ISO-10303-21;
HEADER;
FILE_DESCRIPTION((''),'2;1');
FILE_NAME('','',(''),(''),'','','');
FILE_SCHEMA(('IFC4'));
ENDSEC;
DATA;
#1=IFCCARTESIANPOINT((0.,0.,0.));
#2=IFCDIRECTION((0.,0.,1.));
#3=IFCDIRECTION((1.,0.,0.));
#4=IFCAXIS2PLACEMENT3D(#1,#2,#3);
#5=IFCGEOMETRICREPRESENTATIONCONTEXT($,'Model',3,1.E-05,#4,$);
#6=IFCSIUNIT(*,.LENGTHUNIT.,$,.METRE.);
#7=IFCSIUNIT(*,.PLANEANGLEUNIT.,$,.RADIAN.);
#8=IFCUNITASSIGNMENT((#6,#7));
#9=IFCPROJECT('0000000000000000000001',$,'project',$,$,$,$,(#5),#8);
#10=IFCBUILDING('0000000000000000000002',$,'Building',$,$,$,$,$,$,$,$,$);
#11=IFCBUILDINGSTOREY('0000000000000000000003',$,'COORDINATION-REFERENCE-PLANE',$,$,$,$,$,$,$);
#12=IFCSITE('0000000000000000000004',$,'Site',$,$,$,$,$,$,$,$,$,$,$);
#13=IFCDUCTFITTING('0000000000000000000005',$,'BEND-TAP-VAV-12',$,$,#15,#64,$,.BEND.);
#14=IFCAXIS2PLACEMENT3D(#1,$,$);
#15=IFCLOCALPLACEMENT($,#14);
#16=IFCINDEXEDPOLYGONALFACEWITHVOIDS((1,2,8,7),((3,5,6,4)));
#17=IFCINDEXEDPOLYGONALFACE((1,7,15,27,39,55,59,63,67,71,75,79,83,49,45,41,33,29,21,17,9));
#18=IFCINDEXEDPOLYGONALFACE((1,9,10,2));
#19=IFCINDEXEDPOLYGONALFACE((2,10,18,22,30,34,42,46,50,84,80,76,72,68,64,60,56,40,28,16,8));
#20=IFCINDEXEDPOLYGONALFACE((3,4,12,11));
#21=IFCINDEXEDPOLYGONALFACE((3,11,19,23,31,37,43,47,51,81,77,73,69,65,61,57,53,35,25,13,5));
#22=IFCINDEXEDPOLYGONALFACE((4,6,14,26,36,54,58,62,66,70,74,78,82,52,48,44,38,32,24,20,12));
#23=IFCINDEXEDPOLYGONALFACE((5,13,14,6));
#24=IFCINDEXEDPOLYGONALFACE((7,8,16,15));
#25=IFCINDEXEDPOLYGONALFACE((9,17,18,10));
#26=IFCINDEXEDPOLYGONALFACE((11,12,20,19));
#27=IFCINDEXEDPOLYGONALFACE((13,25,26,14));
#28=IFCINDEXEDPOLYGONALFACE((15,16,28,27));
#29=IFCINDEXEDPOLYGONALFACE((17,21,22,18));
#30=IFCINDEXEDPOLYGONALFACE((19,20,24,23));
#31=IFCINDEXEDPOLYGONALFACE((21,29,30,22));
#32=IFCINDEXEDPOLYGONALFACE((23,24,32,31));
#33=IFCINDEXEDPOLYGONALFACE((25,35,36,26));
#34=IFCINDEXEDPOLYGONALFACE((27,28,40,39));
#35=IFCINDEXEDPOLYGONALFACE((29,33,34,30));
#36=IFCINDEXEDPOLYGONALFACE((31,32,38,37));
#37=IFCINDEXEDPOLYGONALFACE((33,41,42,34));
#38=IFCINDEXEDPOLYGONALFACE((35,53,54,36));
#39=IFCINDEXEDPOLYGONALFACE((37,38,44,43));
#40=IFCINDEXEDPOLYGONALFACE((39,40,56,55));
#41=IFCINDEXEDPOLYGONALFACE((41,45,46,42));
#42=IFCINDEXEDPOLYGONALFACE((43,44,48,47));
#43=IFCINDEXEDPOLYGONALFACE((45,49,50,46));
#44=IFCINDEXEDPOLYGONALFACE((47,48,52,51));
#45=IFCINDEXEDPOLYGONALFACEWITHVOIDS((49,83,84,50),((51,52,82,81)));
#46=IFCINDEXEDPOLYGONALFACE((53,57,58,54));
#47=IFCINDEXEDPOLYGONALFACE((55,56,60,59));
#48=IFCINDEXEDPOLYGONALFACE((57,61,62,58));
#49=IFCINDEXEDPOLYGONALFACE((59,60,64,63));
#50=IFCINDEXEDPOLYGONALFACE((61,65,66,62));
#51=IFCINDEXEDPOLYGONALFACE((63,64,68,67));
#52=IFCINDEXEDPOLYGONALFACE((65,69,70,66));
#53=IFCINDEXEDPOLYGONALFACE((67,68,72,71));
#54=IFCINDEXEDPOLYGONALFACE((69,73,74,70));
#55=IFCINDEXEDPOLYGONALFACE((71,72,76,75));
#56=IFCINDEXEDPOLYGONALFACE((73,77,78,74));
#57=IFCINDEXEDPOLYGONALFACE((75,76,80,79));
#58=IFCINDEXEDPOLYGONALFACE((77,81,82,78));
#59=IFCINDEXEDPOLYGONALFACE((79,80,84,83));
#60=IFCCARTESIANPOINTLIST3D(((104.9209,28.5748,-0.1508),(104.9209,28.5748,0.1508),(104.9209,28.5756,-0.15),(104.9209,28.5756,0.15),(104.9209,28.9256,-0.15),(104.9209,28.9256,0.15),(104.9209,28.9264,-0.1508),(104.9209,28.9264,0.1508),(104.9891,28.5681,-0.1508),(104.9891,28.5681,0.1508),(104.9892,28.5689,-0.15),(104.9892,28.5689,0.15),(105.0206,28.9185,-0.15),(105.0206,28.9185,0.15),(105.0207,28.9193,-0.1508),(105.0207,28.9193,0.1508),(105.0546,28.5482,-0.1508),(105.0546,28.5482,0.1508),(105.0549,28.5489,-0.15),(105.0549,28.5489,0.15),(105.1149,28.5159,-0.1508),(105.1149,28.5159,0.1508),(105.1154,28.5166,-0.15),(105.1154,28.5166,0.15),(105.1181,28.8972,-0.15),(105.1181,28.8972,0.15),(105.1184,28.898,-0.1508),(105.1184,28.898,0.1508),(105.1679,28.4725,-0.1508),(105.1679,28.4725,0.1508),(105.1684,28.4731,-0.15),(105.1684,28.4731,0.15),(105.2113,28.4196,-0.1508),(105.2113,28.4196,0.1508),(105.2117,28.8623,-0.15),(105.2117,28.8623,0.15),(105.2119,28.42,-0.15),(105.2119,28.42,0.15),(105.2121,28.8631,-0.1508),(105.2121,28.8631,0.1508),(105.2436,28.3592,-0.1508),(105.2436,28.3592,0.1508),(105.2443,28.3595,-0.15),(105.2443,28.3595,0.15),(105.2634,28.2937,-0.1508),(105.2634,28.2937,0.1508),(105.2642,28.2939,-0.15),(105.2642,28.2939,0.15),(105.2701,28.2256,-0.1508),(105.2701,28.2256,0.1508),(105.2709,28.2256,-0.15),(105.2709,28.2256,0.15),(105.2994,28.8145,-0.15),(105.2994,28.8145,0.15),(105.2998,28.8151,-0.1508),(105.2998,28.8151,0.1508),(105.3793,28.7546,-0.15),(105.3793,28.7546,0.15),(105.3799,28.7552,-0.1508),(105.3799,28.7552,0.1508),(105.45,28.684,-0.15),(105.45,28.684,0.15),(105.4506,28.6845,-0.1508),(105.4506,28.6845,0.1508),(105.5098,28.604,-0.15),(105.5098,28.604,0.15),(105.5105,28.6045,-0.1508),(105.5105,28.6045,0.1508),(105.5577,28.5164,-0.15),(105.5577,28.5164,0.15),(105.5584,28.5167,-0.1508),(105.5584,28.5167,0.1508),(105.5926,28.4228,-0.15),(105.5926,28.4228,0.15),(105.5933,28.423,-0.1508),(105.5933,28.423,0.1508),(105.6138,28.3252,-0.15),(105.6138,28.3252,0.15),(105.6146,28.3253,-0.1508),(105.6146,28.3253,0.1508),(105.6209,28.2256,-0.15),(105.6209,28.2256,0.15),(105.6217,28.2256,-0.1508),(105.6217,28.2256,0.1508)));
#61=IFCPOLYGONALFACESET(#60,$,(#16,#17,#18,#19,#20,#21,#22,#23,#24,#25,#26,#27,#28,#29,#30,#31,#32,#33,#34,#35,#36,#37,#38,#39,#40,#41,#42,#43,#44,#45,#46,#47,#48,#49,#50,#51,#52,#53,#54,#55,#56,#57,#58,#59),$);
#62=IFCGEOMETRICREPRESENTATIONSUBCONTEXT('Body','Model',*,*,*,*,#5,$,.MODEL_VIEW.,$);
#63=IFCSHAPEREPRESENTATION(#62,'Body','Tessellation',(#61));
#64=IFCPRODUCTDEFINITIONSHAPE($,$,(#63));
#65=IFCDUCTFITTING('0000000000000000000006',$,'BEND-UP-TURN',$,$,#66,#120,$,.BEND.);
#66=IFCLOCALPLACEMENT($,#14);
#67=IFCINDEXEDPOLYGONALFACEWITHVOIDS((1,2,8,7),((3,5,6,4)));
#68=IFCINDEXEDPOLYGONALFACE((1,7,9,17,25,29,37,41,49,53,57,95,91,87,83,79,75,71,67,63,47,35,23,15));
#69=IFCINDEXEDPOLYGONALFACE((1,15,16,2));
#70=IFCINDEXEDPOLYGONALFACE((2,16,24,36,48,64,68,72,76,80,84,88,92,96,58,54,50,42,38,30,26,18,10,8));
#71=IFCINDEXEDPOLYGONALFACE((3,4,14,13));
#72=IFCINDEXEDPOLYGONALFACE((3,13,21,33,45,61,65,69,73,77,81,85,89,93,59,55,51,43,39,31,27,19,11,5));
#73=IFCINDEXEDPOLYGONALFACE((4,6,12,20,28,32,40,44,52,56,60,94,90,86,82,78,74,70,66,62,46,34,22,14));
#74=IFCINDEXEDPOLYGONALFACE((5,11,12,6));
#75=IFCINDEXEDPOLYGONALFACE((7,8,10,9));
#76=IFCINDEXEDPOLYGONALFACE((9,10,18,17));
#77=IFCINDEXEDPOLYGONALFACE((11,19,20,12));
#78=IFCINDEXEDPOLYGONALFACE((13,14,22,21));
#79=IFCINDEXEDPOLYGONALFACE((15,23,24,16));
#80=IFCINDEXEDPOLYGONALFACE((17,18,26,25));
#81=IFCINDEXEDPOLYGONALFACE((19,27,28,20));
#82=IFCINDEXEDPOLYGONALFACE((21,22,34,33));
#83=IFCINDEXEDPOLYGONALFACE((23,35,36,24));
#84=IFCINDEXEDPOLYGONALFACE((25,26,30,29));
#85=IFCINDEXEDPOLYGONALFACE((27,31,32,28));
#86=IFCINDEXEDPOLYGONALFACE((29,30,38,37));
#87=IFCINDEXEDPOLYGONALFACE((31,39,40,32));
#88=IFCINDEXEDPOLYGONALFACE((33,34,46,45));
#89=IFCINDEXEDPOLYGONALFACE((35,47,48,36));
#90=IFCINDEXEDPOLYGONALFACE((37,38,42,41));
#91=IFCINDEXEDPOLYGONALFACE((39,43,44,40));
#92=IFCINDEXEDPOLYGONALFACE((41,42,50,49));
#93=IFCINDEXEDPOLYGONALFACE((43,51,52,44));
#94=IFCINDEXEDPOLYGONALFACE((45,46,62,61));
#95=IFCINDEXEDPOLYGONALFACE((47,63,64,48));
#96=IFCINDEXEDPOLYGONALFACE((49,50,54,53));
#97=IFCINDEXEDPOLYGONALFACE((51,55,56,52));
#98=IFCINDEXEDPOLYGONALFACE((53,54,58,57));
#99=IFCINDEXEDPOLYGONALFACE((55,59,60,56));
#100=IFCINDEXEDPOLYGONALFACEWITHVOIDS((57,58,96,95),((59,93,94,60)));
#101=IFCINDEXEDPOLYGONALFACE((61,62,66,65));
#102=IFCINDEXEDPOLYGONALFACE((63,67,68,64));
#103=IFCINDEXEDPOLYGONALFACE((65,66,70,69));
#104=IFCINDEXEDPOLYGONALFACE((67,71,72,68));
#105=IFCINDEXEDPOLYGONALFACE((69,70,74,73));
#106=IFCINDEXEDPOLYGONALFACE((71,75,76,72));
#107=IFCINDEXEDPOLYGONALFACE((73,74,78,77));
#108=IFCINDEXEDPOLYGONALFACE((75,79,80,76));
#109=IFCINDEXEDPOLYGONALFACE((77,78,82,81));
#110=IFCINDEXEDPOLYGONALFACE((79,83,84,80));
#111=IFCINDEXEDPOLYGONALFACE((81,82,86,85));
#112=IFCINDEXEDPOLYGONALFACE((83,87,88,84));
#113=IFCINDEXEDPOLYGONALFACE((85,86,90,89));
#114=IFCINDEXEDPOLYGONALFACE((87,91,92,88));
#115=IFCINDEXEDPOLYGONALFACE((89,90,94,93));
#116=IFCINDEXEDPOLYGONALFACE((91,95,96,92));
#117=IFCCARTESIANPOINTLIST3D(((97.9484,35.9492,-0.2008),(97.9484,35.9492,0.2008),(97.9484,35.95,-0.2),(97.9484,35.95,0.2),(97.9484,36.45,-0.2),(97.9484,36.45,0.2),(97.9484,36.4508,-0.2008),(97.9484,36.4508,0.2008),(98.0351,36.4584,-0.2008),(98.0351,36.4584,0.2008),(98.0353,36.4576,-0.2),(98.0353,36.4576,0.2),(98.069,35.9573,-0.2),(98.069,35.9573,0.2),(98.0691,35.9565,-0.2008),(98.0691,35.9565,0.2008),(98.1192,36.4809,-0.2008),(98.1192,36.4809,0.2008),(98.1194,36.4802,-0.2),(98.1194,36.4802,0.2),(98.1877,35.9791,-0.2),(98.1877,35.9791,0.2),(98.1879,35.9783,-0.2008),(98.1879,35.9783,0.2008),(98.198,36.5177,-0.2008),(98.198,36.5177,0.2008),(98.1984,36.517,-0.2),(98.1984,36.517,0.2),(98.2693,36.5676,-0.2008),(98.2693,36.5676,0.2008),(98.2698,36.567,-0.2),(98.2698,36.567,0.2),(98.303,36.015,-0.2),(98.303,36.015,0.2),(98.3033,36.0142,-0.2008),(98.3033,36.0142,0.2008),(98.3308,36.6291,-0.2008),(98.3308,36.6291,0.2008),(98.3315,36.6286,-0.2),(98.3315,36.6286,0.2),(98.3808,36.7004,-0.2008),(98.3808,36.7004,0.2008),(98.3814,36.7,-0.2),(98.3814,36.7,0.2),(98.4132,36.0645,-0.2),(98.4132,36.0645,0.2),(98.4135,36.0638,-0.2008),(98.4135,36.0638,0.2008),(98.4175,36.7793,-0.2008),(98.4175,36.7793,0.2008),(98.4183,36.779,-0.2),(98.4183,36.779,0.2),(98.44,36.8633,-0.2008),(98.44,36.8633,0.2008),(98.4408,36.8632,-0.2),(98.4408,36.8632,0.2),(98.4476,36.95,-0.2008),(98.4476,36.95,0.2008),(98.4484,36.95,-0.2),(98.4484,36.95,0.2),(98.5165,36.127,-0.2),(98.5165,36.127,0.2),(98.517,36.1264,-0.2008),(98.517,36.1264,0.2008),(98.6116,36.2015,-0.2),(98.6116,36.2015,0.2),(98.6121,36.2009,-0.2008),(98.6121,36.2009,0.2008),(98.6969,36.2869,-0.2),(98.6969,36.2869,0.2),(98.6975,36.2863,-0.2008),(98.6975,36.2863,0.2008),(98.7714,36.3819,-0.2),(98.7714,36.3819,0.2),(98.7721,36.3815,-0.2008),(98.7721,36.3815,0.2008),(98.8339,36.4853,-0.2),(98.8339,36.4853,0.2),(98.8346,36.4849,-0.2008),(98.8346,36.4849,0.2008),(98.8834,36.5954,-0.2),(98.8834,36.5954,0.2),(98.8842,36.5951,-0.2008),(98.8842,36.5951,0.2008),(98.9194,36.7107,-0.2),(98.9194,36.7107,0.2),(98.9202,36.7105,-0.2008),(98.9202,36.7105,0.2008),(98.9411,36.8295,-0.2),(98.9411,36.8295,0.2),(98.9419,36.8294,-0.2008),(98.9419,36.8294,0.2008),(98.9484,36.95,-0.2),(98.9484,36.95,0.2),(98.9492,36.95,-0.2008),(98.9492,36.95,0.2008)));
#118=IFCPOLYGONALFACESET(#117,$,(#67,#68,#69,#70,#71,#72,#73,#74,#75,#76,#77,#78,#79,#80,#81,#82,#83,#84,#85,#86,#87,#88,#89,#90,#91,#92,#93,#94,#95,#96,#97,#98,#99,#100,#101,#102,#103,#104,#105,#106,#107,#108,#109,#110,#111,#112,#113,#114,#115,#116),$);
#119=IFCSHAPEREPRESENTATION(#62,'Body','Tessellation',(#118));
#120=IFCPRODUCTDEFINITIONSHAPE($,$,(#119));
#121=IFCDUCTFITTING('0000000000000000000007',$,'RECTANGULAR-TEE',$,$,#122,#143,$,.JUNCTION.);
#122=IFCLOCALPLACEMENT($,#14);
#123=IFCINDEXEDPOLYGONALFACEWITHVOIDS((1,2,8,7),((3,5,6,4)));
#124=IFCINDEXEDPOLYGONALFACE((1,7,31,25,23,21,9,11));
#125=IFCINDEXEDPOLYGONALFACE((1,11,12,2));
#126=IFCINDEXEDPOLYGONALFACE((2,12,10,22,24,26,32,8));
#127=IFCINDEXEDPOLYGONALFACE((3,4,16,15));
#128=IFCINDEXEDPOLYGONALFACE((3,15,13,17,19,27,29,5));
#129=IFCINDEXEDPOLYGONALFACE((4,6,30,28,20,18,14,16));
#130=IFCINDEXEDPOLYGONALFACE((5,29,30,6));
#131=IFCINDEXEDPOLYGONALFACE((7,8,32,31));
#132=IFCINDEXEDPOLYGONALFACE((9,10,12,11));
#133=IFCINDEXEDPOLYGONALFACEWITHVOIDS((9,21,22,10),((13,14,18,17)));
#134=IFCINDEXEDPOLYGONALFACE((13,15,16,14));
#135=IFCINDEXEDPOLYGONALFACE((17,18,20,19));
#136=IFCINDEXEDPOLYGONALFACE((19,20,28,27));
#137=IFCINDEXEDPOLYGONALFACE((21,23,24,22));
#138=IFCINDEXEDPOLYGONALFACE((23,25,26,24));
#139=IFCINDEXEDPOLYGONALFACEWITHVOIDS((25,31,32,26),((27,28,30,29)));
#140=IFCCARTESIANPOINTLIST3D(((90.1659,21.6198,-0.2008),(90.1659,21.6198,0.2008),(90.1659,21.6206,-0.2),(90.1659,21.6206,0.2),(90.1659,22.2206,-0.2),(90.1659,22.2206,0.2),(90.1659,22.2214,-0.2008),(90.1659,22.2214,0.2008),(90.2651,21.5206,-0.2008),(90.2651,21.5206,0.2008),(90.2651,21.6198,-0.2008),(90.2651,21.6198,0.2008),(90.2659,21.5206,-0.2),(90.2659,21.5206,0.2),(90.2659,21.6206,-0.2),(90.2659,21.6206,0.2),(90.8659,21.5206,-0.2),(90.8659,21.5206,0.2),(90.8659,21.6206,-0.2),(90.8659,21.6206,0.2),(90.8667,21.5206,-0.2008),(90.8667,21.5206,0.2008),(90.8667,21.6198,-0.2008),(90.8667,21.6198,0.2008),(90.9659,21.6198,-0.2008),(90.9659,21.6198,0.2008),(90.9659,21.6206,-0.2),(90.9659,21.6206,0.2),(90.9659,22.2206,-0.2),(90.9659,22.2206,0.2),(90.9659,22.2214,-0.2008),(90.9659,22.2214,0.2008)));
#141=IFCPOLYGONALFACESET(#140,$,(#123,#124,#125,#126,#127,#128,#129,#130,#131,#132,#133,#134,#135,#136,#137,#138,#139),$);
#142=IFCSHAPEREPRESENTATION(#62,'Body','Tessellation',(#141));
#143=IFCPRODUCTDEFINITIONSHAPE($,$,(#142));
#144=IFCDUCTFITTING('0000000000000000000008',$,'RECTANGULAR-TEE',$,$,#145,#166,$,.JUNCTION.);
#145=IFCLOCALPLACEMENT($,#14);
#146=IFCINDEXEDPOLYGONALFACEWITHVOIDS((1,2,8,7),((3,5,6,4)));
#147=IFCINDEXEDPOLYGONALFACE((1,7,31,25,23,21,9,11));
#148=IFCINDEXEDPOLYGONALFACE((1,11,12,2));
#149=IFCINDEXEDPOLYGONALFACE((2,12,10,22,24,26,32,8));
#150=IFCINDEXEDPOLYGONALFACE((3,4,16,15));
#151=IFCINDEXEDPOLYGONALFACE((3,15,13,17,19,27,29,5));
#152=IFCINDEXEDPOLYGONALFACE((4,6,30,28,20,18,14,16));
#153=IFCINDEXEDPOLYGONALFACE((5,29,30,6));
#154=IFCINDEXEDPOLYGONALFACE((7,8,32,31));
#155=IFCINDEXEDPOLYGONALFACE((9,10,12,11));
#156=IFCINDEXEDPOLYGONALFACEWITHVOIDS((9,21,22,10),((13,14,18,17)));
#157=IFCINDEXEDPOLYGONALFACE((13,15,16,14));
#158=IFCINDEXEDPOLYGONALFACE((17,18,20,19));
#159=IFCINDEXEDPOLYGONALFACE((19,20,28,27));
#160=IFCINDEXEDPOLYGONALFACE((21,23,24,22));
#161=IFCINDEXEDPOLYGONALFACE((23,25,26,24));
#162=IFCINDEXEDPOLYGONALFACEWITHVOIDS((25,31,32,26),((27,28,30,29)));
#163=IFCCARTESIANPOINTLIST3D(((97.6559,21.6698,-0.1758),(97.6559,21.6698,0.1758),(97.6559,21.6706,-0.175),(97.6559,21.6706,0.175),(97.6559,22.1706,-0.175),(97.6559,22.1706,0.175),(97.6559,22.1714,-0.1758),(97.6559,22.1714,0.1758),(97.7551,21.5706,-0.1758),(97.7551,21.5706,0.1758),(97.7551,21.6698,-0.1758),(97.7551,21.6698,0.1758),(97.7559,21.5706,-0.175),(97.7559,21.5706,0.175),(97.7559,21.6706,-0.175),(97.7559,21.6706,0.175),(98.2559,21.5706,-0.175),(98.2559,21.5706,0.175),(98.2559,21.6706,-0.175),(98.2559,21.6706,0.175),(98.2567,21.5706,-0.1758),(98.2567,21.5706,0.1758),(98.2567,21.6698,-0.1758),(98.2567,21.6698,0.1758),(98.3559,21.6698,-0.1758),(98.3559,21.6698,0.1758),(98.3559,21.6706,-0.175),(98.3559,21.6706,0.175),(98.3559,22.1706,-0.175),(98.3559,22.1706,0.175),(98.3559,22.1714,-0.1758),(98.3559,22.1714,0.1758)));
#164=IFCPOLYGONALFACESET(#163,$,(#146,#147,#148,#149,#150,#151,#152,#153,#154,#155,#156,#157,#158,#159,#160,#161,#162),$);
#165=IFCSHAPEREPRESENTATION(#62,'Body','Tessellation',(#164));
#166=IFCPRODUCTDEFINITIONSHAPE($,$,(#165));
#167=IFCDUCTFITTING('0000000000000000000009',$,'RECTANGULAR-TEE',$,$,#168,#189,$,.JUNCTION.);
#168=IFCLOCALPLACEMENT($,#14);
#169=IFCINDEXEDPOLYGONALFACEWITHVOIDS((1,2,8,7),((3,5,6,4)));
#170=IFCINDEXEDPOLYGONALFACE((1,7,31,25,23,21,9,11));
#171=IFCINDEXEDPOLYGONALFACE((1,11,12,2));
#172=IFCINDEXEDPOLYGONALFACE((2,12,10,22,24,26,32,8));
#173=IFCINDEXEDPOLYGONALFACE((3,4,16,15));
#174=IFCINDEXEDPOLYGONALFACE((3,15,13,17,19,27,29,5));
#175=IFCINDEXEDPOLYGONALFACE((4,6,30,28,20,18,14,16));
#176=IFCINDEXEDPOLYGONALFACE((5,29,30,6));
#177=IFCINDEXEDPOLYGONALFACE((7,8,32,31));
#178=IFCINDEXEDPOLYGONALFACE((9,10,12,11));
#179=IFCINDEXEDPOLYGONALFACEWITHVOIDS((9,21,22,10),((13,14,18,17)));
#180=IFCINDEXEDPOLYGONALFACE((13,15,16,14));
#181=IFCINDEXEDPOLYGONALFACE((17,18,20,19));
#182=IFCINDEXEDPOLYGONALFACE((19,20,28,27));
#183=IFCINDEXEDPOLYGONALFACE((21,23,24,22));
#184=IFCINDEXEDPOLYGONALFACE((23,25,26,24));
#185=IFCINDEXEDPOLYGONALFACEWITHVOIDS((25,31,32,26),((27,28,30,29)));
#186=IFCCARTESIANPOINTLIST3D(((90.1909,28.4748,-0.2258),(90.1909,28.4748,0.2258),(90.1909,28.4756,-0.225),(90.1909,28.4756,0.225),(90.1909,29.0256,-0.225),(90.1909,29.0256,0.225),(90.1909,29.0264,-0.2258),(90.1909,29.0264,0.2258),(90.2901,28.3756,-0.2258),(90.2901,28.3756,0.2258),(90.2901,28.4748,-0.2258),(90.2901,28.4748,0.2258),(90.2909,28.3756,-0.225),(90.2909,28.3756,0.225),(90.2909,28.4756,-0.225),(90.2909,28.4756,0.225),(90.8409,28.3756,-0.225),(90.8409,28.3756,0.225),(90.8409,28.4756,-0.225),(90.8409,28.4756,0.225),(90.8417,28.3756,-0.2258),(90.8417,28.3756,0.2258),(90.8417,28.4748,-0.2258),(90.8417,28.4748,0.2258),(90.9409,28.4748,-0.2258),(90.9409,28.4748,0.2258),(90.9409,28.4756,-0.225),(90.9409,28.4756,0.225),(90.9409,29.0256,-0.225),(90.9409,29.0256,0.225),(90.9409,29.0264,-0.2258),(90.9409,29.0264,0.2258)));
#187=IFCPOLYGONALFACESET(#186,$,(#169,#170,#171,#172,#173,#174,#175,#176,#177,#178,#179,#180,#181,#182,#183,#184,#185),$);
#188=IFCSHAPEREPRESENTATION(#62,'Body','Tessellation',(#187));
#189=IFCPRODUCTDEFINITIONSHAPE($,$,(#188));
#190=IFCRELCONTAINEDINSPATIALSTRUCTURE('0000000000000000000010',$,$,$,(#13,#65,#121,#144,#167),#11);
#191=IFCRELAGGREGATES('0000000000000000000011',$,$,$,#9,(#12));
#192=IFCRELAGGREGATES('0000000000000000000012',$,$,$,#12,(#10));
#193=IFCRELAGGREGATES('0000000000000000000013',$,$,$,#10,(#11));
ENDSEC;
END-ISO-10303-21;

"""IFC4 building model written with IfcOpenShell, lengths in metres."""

from ifc_helpers import new_model, entity, si_unit, frame, origin_with_axes, place, context, subcontext, project, spatial, rectangle, extrude, boolean, element, save


model = new_model("IFC4")

# Units and contexts
model_context = context("Model", 3, precision=1e-05, world=origin_with_axes())
body_context = subcontext(model_context, "Body", "Model", "MODEL_VIEW")
ifc_project = project(units=[si_unit("LENGTHUNIT", "METRE"), si_unit("PLANEANGLEUNIT", "RADIAN")], contexts=[model_context])

# Site, building, storey
site = spatial("IfcSite", under=ifc_project, Name="Site")
building = spatial("IfcBuilding", under=site, Name="Building")
storey = spatial("IfcBuildingStorey", under=building, Name="COORDINATION-REFERENCE-PLANE")

# Duct fittings
duct_fitting_1_placement = place(None, frame((104.9209, 28.2256, 0.0), z_axis=(0.0, 0.0, -1.0), x_axis=(0.0, 1.0, 0.0)))
cartesian_point_1 = entity("IfcCartesianPoint", [0.0, 0.0, 0.0])
element("IfcDuctFitting", 1, at=duct_fitting_1_placement, inside=storey, Name="BEND-TAP-VAV-12", PredefinedType="BEND", context=body_context, shape_type="SweptSolid", body=[
    entity("IfcRevolvedAreaSolid", entity("IfcRectangleHollowProfileDef", "AREA", None, entity("IfcAxis2Placement2D", entity("IfcCartesianPoint", [0.525, 0.0])), 0.3516, 0.3016, 0.0008), entity("IfcAxis2Placement3D", cartesian_point_1, entity("IfcDirection", [0.0, -1.0, 0.0]), entity("IfcDirection", [1.0, 0.0, 0.0])), entity("IfcAxis1Placement", cartesian_point_1, entity("IfcDirection", [0.0, 1.0, 0.0])), 1.570796),
])
duct_fitting_2_placement = place(None, frame((97.9484, 36.95, 0.0), z_axis=(0.0, 0.0, 1.0), x_axis=(0.0, -1.0, 0.0)))
cartesian_point_2 = entity("IfcCartesianPoint", [0.0, 0.0, 0.0])
element("IfcDuctFitting", 2, at=duct_fitting_2_placement, inside=storey, Name="BEND-UP-TURN", PredefinedType="BEND", context=body_context, shape_type="SweptSolid", body=[
    entity("IfcRevolvedAreaSolid", entity("IfcRectangleHollowProfileDef", "AREA", None, entity("IfcAxis2Placement2D", entity("IfcCartesianPoint", [0.75, 0.0])), 0.5016, 0.4016, 0.0008), entity("IfcAxis2Placement3D", cartesian_point_2, entity("IfcDirection", [0.0, -1.0, 0.0]), entity("IfcDirection", [1.0, 0.0, 0.0])), entity("IfcAxis1Placement", cartesian_point_2, entity("IfcDirection", [0.0, 1.0, 0.0])), 1.570796),
])
duct_fitting_3_placement = place(None, frame((90.5659, 21.9206, 0.0), z_axis=(1.0, 0.0, 0.0), x_axis=(0.0, -1.0, 0.0)))
solid_1 = boolean("UNION", extrude(rectangle(XDim=0.6, YDim=0.4), frame((0.0, 0.0, -0.4), z_axis=(0.0, 0.0, 1.0), x_axis=(1.0, 0.0, 0.0)), (0.0, 0.0, 1.0), 0.8), extrude(rectangle(XDim=0.6, YDim=0.4), frame((0.0, 0.0, 0.0), z_axis=(1.0, 0.0, 0.0), x_axis=(0.0, 0.0, -1.0)), (0.0, 0.0, 1.0), 0.4))
element("IfcDuctFitting", 3, at=duct_fitting_3_placement, inside=storey, Name="RECTANGULAR-TEE", PredefinedType="JUNCTION", context=body_context, shape_type="CSG", body=[
    boolean("DIFFERENCE", boolean("UNION", extrude(rectangle(XDim=0.6016, YDim=0.4016), frame((0.0, 0.0, -0.4), z_axis=(0.0, 0.0, 1.0), x_axis=(1.0, 0.0, 0.0)), (0.0, 0.0, 1.0), 0.8), extrude(rectangle(XDim=0.6016, YDim=0.4016), frame((0.0, 0.0, 0.0), z_axis=(1.0, 0.0, 0.0), x_axis=(0.0, 0.0, -1.0)), (0.0, 0.0, 1.0), 0.4)), solid_1),
])
duct_fitting_4_placement = place(None, frame((98.0059, 21.9206, 0.0), z_axis=(1.0, 0.0, 0.0), x_axis=(0.0, -1.0, 0.0)))
solid_2 = boolean("UNION", extrude(rectangle(XDim=0.5, YDim=0.35), frame((0.0, 0.0, -0.35), z_axis=(0.0, 0.0, 1.0), x_axis=(1.0, 0.0, 0.0)), (0.0, 0.0, 1.0), 0.7), extrude(rectangle(XDim=0.5, YDim=0.35), frame((0.0, 0.0, 0.0), z_axis=(1.0, 0.0, 0.0), x_axis=(0.0, 0.0, -1.0)), (0.0, 0.0, 1.0), 0.35))
element("IfcDuctFitting", 4, at=duct_fitting_4_placement, inside=storey, Name="RECTANGULAR-TEE", PredefinedType="JUNCTION", context=body_context, shape_type="CSG", body=[
    boolean("DIFFERENCE", boolean("UNION", extrude(rectangle(XDim=0.5016, YDim=0.3516), frame((0.0, 0.0, -0.35), z_axis=(0.0, 0.0, 1.0), x_axis=(1.0, 0.0, 0.0)), (0.0, 0.0, 1.0), 0.7), extrude(rectangle(XDim=0.5016, YDim=0.3516), frame((0.0, 0.0, 0.0), z_axis=(1.0, 0.0, 0.0), x_axis=(0.0, 0.0, -1.0)), (0.0, 0.0, 1.0), 0.35)), solid_2),
])
duct_fitting_5_placement = place(None, frame((90.5659, 28.7506, 0.0), z_axis=(1.0, 0.0, 0.0), x_axis=(0.0, -1.0, 0.0)))
solid_3 = boolean("UNION", extrude(rectangle(XDim=0.55, YDim=0.45), frame((0.0, 0.0, -0.375), z_axis=(0.0, 0.0, 1.0), x_axis=(1.0, 0.0, 0.0)), (0.0, 0.0, 1.0), 0.75), extrude(rectangle(XDim=0.55, YDim=0.45), frame((0.0, 0.0, 0.0), z_axis=(1.0, 0.0, 0.0), x_axis=(0.0, 0.0, -1.0)), (0.0, 0.0, 1.0), 0.375))
element("IfcDuctFitting", 5, at=duct_fitting_5_placement, inside=storey, Name="RECTANGULAR-TEE", PredefinedType="JUNCTION", context=body_context, shape_type="CSG", body=[
    boolean("DIFFERENCE", boolean("UNION", extrude(rectangle(XDim=0.5516, YDim=0.4516), frame((0.0, 0.0, -0.375), z_axis=(0.0, 0.0, 1.0), x_axis=(1.0, 0.0, 0.0)), (0.0, 0.0, 1.0), 0.75), extrude(rectangle(XDim=0.5516, YDim=0.4516), frame((0.0, 0.0, 0.0), z_axis=(1.0, 0.0, 0.0), x_axis=(0.0, 0.0, -1.0)), (0.0, 0.0, 1.0), 0.375)), solid_3),
])

save(model, "model.ifc")
